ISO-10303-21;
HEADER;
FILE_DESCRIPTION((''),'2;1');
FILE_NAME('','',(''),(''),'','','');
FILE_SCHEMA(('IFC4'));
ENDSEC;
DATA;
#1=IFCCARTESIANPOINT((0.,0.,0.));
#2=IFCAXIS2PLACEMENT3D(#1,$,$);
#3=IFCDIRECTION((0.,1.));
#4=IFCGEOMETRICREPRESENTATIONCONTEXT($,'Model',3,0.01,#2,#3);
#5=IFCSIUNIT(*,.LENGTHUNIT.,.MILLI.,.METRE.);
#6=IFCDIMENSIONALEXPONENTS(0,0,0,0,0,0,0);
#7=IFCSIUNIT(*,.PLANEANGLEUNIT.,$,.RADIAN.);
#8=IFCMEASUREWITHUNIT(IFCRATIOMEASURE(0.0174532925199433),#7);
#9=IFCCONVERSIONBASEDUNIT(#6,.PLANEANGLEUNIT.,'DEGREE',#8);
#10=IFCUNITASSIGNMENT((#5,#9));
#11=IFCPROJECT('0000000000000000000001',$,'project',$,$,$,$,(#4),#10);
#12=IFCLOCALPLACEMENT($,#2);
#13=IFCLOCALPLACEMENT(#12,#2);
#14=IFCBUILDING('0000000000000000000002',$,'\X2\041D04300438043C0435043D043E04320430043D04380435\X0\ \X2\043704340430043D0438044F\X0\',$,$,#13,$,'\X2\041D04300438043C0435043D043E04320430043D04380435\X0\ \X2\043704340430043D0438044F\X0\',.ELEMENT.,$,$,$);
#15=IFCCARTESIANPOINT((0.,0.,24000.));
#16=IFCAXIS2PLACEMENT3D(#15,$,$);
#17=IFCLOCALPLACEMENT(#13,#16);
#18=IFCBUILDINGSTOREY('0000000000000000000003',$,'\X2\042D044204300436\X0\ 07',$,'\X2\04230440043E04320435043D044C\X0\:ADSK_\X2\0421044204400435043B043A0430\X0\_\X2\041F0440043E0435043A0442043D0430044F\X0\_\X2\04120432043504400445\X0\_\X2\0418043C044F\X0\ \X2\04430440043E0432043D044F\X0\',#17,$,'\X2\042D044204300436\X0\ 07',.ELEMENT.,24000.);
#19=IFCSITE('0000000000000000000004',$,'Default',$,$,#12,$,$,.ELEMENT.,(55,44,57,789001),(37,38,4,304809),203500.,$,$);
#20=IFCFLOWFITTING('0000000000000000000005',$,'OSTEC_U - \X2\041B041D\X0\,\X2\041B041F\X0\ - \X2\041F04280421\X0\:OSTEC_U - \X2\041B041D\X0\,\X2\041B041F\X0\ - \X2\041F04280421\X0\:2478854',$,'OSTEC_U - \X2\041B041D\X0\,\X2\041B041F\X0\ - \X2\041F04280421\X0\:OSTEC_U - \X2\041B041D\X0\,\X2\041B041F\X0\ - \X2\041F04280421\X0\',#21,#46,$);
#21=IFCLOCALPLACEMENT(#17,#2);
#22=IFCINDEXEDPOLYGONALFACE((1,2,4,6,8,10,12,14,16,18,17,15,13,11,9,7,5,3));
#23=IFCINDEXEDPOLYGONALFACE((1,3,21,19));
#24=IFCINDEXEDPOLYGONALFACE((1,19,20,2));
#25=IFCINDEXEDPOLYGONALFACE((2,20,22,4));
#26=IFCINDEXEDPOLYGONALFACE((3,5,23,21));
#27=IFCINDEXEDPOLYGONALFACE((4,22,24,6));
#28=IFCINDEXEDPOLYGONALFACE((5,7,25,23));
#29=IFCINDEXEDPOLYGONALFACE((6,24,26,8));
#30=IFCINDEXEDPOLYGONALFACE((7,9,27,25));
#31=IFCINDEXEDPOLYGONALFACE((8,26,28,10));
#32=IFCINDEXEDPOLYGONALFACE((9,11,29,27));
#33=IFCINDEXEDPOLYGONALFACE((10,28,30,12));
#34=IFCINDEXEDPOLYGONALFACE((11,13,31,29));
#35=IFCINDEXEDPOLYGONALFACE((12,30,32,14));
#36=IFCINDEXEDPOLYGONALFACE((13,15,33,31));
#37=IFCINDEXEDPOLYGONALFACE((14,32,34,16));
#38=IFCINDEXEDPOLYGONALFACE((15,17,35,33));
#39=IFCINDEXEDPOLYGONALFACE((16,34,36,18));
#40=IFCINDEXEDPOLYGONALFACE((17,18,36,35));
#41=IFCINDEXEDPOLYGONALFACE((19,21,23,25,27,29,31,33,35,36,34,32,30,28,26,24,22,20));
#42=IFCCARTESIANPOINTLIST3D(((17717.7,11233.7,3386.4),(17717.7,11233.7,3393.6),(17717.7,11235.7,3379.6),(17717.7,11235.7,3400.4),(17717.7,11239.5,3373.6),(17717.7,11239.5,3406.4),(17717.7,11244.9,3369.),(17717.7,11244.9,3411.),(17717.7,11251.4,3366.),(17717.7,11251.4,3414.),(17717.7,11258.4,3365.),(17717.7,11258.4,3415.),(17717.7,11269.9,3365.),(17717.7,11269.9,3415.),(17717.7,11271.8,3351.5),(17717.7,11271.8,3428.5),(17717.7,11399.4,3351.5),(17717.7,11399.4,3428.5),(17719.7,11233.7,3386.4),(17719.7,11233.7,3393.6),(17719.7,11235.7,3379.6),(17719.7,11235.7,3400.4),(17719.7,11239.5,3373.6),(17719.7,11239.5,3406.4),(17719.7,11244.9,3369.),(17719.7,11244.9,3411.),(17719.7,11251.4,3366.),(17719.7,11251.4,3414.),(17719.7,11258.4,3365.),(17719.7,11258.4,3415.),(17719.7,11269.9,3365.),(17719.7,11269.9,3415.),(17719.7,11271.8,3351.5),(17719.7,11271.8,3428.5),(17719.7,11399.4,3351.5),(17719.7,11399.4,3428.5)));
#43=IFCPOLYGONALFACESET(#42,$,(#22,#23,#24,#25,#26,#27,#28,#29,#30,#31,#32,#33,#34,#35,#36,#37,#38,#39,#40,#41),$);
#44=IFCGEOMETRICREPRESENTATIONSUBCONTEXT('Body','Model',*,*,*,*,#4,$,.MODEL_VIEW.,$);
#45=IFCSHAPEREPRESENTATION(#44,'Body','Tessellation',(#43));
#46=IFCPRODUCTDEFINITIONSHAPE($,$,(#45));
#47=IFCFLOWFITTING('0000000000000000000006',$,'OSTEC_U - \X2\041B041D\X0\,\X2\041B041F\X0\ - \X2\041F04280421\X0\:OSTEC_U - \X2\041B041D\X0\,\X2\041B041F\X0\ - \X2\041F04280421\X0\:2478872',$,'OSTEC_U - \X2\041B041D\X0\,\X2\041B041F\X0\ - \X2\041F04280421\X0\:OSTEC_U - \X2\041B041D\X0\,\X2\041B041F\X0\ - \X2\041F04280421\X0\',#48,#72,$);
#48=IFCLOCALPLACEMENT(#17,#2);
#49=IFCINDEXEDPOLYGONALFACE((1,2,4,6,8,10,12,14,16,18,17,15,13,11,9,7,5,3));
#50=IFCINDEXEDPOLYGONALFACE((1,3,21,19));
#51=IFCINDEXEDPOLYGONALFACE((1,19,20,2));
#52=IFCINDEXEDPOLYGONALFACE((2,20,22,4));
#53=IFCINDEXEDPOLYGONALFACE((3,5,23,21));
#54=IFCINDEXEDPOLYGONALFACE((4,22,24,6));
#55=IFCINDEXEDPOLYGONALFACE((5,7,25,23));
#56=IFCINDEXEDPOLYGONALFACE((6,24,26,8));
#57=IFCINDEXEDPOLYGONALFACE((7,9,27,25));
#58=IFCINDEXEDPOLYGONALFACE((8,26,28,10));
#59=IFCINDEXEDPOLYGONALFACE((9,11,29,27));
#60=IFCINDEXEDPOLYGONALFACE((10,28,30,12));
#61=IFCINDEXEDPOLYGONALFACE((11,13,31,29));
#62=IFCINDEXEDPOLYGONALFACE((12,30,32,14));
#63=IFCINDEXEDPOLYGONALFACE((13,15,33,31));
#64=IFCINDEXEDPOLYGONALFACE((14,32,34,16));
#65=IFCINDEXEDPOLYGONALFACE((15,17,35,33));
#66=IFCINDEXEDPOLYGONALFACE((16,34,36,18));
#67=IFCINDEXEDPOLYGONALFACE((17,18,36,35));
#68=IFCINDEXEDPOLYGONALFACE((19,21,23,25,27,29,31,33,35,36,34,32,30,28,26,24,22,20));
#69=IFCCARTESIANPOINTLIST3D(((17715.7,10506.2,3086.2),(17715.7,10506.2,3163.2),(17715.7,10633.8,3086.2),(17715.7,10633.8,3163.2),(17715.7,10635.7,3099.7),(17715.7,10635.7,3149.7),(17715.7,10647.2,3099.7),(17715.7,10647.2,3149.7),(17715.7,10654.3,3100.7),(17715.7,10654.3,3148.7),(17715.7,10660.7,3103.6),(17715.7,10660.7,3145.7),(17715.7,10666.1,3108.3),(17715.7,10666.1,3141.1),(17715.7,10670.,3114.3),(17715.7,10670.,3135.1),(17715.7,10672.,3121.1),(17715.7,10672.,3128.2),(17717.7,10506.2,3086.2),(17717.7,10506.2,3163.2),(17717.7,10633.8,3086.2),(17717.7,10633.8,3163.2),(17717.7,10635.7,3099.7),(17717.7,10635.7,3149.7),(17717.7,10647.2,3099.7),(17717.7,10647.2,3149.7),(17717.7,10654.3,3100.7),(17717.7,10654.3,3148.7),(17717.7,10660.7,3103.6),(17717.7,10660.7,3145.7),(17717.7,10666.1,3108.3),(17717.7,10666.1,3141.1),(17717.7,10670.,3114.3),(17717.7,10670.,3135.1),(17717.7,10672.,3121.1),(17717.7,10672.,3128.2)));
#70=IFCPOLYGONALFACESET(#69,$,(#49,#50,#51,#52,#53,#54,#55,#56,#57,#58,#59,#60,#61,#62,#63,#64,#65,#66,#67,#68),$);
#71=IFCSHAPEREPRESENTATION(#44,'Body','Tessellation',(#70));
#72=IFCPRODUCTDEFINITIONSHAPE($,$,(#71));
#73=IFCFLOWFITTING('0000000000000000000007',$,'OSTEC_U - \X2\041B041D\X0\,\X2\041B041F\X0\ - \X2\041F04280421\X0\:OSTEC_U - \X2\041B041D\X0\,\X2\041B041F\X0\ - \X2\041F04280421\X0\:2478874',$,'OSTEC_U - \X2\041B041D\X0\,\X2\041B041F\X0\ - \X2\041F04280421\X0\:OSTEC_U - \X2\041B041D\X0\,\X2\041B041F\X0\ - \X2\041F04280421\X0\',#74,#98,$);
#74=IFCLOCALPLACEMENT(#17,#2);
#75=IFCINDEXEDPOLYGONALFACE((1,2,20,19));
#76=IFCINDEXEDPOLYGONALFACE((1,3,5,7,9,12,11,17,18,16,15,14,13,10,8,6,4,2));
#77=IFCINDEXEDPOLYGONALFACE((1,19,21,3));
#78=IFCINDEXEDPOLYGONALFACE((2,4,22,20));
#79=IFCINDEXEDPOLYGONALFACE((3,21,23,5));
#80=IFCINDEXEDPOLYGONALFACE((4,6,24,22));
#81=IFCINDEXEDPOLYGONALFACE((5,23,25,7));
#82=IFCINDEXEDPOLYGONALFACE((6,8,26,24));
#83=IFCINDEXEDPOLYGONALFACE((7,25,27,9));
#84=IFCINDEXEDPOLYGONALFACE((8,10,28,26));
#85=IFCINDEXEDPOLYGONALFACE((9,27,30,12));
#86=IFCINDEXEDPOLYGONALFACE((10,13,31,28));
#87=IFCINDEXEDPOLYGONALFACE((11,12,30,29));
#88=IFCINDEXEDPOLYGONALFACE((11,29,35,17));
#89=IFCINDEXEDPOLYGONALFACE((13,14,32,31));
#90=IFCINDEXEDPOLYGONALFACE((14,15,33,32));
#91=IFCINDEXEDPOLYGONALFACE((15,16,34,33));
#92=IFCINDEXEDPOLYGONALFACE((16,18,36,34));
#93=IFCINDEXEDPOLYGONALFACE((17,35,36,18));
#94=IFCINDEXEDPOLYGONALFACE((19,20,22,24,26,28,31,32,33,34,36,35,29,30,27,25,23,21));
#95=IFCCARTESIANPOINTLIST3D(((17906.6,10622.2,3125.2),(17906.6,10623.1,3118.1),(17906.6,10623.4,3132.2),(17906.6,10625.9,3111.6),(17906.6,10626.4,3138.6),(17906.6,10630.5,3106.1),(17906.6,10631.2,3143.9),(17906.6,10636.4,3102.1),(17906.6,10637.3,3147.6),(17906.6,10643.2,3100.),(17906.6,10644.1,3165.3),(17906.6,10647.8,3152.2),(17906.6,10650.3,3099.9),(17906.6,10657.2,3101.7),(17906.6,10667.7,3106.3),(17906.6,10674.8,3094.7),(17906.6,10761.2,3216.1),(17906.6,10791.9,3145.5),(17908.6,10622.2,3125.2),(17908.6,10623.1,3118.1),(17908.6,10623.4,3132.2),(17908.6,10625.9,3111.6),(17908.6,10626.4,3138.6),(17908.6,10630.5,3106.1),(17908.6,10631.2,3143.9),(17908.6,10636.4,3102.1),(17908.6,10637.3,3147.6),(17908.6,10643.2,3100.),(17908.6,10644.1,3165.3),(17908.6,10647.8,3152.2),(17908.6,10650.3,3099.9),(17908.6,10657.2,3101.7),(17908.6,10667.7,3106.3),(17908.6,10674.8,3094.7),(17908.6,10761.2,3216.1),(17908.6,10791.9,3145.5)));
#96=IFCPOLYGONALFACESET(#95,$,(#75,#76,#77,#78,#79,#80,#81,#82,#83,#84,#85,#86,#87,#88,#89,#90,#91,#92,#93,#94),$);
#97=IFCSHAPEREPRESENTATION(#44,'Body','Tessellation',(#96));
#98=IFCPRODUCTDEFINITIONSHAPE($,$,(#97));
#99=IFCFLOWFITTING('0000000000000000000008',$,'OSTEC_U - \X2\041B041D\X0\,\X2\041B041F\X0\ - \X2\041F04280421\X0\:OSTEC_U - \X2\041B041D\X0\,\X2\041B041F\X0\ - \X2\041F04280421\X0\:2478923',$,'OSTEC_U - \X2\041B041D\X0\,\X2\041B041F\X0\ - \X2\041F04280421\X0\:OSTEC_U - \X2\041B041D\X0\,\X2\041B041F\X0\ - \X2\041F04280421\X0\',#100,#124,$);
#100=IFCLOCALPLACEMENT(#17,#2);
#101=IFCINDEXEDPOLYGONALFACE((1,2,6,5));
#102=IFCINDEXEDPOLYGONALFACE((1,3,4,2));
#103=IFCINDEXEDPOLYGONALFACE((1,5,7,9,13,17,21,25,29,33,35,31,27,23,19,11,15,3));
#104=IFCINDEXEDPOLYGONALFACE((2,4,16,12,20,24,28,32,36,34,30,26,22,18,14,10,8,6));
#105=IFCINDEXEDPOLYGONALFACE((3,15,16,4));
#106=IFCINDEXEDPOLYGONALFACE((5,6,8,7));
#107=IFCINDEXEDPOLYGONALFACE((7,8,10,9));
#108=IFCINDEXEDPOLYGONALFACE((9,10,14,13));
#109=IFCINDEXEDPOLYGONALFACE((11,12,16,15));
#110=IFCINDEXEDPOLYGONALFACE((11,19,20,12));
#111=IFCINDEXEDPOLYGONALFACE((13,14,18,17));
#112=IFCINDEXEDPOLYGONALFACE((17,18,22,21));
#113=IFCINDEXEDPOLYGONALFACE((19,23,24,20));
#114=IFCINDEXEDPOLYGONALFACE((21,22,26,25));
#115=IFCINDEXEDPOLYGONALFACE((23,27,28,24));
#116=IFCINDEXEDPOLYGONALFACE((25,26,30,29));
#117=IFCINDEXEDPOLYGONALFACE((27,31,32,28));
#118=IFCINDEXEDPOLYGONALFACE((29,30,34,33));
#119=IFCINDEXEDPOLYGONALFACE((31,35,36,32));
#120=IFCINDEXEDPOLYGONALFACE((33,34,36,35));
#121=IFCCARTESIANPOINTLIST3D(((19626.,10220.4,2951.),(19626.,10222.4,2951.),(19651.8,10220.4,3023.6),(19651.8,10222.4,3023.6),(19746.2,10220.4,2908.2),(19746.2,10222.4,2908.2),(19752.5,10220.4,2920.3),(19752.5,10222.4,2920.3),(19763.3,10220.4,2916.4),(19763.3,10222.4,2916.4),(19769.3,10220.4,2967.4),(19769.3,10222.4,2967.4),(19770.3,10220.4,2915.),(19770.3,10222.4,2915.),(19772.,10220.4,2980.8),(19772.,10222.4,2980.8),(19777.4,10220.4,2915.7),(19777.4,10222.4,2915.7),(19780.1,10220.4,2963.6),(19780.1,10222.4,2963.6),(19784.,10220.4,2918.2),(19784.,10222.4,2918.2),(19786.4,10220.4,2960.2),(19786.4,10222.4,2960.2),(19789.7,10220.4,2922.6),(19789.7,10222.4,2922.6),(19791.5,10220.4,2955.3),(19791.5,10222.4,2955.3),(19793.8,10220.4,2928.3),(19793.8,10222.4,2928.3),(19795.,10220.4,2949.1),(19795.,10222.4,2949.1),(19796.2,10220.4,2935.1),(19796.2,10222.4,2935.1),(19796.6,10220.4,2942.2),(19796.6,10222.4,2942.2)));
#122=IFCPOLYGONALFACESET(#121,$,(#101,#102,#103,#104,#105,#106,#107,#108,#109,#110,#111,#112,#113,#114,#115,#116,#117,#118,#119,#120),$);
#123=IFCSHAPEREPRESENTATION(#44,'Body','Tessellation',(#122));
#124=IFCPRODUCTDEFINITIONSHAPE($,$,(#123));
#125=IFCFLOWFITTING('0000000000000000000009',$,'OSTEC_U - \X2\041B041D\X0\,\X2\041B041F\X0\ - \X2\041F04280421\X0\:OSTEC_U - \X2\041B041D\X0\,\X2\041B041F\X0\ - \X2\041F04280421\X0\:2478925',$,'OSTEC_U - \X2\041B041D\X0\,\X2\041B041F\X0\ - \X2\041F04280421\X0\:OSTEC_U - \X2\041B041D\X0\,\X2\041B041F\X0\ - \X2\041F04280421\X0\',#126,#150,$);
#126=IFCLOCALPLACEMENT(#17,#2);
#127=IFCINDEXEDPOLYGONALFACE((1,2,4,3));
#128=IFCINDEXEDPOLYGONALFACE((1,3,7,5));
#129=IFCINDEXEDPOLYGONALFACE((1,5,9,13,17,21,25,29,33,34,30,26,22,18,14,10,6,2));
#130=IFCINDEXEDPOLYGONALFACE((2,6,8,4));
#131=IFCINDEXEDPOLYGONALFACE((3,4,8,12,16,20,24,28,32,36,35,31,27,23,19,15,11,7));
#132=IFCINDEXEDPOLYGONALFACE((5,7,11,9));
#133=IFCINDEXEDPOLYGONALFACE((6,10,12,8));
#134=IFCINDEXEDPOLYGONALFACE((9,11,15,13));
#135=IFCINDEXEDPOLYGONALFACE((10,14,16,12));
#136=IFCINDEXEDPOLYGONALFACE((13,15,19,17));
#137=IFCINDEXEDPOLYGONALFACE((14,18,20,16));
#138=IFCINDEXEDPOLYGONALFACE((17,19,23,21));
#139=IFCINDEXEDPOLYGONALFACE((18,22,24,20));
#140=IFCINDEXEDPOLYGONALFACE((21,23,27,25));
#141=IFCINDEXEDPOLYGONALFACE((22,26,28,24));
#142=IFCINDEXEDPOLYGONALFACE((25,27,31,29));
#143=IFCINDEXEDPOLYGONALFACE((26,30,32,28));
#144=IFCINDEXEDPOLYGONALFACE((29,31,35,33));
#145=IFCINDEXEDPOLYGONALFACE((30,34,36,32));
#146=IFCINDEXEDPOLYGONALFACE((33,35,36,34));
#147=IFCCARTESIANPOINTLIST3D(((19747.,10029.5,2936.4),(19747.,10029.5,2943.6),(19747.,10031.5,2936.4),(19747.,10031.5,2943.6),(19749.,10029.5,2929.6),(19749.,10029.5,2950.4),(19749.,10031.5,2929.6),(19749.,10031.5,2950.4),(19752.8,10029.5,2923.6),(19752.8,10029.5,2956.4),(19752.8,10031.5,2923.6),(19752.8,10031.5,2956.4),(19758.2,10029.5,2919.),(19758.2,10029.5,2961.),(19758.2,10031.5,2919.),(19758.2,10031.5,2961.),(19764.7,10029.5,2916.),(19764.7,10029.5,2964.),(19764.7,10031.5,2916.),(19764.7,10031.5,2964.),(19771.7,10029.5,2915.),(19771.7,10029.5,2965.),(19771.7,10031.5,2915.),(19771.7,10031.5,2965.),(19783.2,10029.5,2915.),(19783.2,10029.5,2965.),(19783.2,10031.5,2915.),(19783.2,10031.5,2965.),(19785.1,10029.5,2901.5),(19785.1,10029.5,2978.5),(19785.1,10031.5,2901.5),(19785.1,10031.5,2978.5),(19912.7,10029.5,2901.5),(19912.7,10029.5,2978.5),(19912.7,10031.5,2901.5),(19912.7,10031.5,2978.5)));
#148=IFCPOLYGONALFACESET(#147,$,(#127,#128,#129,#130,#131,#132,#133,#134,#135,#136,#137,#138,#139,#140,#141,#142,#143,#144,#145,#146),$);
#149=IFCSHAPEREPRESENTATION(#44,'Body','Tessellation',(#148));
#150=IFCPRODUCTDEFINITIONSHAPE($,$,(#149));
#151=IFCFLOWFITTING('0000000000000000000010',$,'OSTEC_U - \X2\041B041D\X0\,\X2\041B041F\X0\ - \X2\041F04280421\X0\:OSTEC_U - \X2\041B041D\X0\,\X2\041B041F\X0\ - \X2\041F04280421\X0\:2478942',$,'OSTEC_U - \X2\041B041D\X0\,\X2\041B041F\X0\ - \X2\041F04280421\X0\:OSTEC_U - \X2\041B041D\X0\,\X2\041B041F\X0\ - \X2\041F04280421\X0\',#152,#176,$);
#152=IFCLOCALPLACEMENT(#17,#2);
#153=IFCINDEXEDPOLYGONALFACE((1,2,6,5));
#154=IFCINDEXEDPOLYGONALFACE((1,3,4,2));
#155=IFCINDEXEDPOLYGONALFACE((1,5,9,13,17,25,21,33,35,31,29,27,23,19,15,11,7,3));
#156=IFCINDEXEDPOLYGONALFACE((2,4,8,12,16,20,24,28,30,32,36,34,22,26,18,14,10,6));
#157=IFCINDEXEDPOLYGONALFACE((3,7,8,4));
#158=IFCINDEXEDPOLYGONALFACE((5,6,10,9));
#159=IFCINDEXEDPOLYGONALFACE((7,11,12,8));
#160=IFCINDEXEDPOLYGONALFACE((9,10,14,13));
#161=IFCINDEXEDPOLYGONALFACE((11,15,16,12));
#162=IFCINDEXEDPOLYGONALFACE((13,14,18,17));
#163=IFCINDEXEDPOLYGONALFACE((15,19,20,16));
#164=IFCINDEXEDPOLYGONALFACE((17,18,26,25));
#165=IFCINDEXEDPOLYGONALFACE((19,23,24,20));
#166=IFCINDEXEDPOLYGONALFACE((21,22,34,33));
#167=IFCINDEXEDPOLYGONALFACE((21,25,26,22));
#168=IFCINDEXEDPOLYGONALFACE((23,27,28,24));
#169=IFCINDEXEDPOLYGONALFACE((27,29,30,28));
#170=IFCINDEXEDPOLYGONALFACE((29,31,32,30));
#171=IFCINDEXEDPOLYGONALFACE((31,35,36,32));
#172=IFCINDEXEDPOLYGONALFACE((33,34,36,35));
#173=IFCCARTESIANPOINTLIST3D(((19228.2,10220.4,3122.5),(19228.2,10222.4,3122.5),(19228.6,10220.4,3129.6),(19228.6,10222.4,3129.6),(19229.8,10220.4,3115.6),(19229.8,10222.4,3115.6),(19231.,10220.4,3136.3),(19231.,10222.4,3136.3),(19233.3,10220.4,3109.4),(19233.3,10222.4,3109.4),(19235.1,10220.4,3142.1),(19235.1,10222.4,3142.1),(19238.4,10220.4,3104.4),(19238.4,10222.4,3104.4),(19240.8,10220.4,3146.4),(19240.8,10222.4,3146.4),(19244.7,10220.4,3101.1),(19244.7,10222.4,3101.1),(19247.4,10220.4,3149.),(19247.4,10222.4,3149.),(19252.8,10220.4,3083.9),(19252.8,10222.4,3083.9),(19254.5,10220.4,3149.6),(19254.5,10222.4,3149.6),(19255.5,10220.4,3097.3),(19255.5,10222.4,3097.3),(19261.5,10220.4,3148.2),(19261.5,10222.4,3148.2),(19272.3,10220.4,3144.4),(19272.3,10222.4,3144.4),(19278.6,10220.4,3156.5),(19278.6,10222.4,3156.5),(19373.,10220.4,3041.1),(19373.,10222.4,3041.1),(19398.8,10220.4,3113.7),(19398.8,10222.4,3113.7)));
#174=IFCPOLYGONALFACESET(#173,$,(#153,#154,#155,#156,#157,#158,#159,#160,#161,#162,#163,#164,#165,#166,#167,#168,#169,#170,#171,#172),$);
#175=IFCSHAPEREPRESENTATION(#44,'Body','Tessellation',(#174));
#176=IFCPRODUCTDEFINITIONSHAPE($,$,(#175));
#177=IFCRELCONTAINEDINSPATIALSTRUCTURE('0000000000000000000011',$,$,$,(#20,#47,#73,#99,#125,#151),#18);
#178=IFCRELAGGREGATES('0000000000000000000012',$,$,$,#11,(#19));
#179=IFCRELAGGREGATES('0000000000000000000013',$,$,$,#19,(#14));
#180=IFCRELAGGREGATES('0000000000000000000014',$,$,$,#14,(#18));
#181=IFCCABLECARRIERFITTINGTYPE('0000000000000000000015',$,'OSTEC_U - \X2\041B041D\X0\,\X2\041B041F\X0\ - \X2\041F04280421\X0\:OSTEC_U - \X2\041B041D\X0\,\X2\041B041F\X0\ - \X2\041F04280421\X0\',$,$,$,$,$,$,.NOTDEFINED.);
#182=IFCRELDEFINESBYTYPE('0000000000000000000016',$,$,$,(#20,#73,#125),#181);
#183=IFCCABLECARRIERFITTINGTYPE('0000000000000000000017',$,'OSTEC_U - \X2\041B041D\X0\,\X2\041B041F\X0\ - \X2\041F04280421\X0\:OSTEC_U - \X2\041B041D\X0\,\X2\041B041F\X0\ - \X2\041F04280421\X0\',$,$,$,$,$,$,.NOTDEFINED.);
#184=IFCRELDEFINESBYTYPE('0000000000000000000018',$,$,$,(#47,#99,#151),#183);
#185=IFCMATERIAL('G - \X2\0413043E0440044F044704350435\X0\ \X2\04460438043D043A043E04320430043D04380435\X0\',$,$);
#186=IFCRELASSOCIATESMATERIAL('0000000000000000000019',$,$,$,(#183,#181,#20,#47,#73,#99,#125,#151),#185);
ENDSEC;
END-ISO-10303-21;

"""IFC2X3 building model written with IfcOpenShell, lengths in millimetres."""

from ifc_helpers import new_model, entity, si_unit, converted_unit, direction, frame, frame_2d, origin, place, context, subcontext, project, spatial, polyline, circle_curve, parameter, trimmed, segment, composite_curve, outline, extrude, source, transform, mapped, material, type_object, type_shapes, element, save


model = new_model("IFC2X3")

# Units and contexts
model_context = context("Model", 3, precision=0.01, world=origin(), true_north=direction((0.0, 1.0)))
body_context = subcontext(model_context, "Body", "Model", "MODEL_VIEW")
ifc_project = project(units=[si_unit("LENGTHUNIT", "METRE", prefix="MILLI"), converted_unit("PLANEANGLEUNIT", "DEGREE", entity("IfcRatioMeasure", 0.0174532925199433), si_unit("PLANEANGLEUNIT", "RADIAN"), dimensions=[0, 0, 0, 0, 0, 0, 0])], contexts=[model_context])

# Site, building, storey
site_placement = place(None, origin())
site = spatial("IfcSite", under=ifc_project, at=site_placement, Name="Default", CompositionType="ELEMENT", RefLatitude=(55, 44, 57, 789001), RefLongitude=(37, 38, 4, 304809), RefElevation=203500.0)
building_placement = place(site_placement, origin())
building = spatial("IfcBuilding", under=site, at=building_placement, Name="Наименование здания", LongName="Наименование здания", CompositionType="ELEMENT")
storey_placement = place(building_placement, frame((0.0, 0.0, 24000.0)))
storey = spatial("IfcBuildingStorey", under=building, at=storey_placement, Name="Этаж 07", ObjectType="Уровень:ADSK_Стрелка_Проектная_Вверх_Имя уровня", LongName="Этаж 07", CompositionType="ELEMENT", Elevation=24000.0)

# Flow fittings
ifc_material = material(Name="G - Горячее цинкование")
cable_carrier_fitting_type_1 = type_object("IfcCableCarrierFittingType", Name="OSTEC_U - ЛН,ЛП - ПШС:OSTEC_U - ЛН,ЛП - ПШС", PredefinedType="NOTDEFINED", material=ifc_material)
shared_shape_1 = source(origin(), body_context, "Body", "SweptSolid", [
    extrude(outline(composite_curve([segment(trimmed(circle_curve(frame_2d((-41.5, 0.0), x_axis=(1.0, 0.0)), 25.0), [parameter(90.0)], [parameter(270.0)], True, "PARAMETER"), True, "CONTINUOUS"), segment(polyline([(-41.5, -25.0), (-30.0, -25.0)]), True, "CONTINUOUS"), segment(polyline([(-30.0, -25.0), (-28.1, -38.5)]), True, "CONTINUOUS"), segment(polyline([(-28.1, -38.5), (99.5, -38.5)]), True, "CONTINUOUS"), segment(polyline([(99.5, -38.5), (99.5, 38.5)]), True, "CONTINUOUS"), segment(polyline([(99.5, 38.5), (-28.1, 38.5)]), True, "CONTINUOUS"), segment(polyline([(-28.1, 38.5), (-30.0, 25.0)]), True, "CONTINUOUS"), segment(polyline([(-30.0, 25.0), (-41.5, 25.0)]), True, "CONTINUOUS")], self_intersect=False)), frame((41.5, 0.0, 0.0), z_axis=(0.0, 0.0, -1.0), x_axis=(1.0, 0.0, 0.0)), (0.0, 0.0, -1.0), 2.0),
])
type_shapes(cable_carrier_fitting_type_1, [shared_shape_1])
cable_carrier_fitting_type_2 = type_object("IfcCableCarrierFittingType", Name="OSTEC_U - ЛН,ЛП - ПШС:OSTEC_U - ЛН,ЛП - ПШС", PredefinedType="NOTDEFINED", material=ifc_material)
type_shapes(cable_carrier_fitting_type_2, [shared_shape_1])
flow_fitting_1_placement = place(storey_placement, frame((17719.7, 11258.4, 3390.0), z_axis=(-1.0, 0.0, 0.0), x_axis=(0.0, 1.0, 0.0)))
element("IfcFlowFitting", 1, at=flow_fitting_1_placement, inside=storey, type_object=cable_carrier_fitting_type_2, material=ifc_material, Name="OSTEC_U - ЛН,ЛП - ПШС:OSTEC_U - ЛН,ЛП - ПШС:2478854", ObjectType="OSTEC_U - ЛН,ЛП - ПШС:OSTEC_U - ЛН,ЛП - ПШС", context=body_context, shape_type="MappedRepresentation", body=[
    mapped(shared_shape_1, transform((0.0, 0.0, 0.0), scale=1.0)),
])
flow_fitting_2_placement = place(storey_placement, frame((17717.7, 10647.2, 3124.7), z_axis=(-1.0, 0.0, 0.0), x_axis=(0.0, -1.0, 0.0)))
element("IfcFlowFitting", 2, at=flow_fitting_2_placement, inside=storey, type_object=cable_carrier_fitting_type_1, material=ifc_material, Name="OSTEC_U - ЛН,ЛП - ПШС:OSTEC_U - ЛН,ЛП - ПШС:2478872", ObjectType="OSTEC_U - ЛН,ЛП - ПШС:OSTEC_U - ЛН,ЛП - ПШС", context=body_context, shape_type="MappedRepresentation", body=[
    mapped(shared_shape_1, transform((0.0, 0.0, 0.0), scale=1.0)),
])
flow_fitting_3_placement = place(storey_placement, frame((17906.6, 10647.2, 3124.7), z_axis=(1.0, 0.0, 0.0), x_axis=(0.0, 0.917307, 0.398181)))
element("IfcFlowFitting", 3, at=flow_fitting_3_placement, inside=storey, type_object=cable_carrier_fitting_type_2, material=ifc_material, Name="OSTEC_U - ЛН,ЛП - ПШС:OSTEC_U - ЛН,ЛП - ПШС:2478874", ObjectType="OSTEC_U - ЛН,ЛП - ПШС:OSTEC_U - ЛН,ЛП - ПШС", context=body_context, shape_type="MappedRepresentation", body=[
    mapped(shared_shape_1, transform((0.0, 0.0, 0.0), scale=1.0)),
])
flow_fitting_4_placement = place(storey_placement, frame((19771.7, 10220.4, 2940.0), z_axis=(0.0, 1.0, 0.0), x_axis=(-0.942059, 0.0, 0.335447)))
element("IfcFlowFitting", 4, at=flow_fitting_4_placement, inside=storey, type_object=cable_carrier_fitting_type_1, material=ifc_material, Name="OSTEC_U - ЛН,ЛП - ПШС:OSTEC_U - ЛН,ЛП - ПШС:2478923", ObjectType="OSTEC_U - ЛН,ЛП - ПШС:OSTEC_U - ЛН,ЛП - ПШС", context=body_context, shape_type="MappedRepresentation", body=[
    mapped(shared_shape_1, transform((0.0, 0.0, 0.0), scale=1.0)),
])
flow_fitting_5_placement = place(storey_placement, frame((19771.7, 10031.5, 2940.0), z_axis=(0.0, -1.0, 0.0), x_axis=(1.0, 0.0, 0.0)))
element("IfcFlowFitting", 5, at=flow_fitting_5_placement, inside=storey, type_object=cable_carrier_fitting_type_2, material=ifc_material, Name="OSTEC_U - ЛН,ЛП - ПШС:OSTEC_U - ЛН,ЛП - ПШС:2478925", ObjectType="OSTEC_U - ЛН,ЛП - ПШС:OSTEC_U - ЛН,ЛП - ПШС", context=body_context, shape_type="MappedRepresentation", body=[
    mapped(shared_shape_1, transform((0.0, 0.0, 0.0), scale=1.0)),
])
flow_fitting_6_placement = place(storey_placement, frame((19253.1, 10220.4, 3124.7), z_axis=(0.0, 1.0, 0.0), x_axis=(0.942059, 0.0, -0.335447)))
element("IfcFlowFitting", 6, at=flow_fitting_6_placement, inside=storey, type_object=cable_carrier_fitting_type_1, material=ifc_material, Name="OSTEC_U - ЛН,ЛП - ПШС:OSTEC_U - ЛН,ЛП - ПШС:2478942", ObjectType="OSTEC_U - ЛН,ЛП - ПШС:OSTEC_U - ЛН,ЛП - ПШС", context=body_context, shape_type="MappedRepresentation", body=[
    mapped(shared_shape_1, transform((0.0, 0.0, 0.0), scale=1.0)),
])

save(model, "model.ifc")
